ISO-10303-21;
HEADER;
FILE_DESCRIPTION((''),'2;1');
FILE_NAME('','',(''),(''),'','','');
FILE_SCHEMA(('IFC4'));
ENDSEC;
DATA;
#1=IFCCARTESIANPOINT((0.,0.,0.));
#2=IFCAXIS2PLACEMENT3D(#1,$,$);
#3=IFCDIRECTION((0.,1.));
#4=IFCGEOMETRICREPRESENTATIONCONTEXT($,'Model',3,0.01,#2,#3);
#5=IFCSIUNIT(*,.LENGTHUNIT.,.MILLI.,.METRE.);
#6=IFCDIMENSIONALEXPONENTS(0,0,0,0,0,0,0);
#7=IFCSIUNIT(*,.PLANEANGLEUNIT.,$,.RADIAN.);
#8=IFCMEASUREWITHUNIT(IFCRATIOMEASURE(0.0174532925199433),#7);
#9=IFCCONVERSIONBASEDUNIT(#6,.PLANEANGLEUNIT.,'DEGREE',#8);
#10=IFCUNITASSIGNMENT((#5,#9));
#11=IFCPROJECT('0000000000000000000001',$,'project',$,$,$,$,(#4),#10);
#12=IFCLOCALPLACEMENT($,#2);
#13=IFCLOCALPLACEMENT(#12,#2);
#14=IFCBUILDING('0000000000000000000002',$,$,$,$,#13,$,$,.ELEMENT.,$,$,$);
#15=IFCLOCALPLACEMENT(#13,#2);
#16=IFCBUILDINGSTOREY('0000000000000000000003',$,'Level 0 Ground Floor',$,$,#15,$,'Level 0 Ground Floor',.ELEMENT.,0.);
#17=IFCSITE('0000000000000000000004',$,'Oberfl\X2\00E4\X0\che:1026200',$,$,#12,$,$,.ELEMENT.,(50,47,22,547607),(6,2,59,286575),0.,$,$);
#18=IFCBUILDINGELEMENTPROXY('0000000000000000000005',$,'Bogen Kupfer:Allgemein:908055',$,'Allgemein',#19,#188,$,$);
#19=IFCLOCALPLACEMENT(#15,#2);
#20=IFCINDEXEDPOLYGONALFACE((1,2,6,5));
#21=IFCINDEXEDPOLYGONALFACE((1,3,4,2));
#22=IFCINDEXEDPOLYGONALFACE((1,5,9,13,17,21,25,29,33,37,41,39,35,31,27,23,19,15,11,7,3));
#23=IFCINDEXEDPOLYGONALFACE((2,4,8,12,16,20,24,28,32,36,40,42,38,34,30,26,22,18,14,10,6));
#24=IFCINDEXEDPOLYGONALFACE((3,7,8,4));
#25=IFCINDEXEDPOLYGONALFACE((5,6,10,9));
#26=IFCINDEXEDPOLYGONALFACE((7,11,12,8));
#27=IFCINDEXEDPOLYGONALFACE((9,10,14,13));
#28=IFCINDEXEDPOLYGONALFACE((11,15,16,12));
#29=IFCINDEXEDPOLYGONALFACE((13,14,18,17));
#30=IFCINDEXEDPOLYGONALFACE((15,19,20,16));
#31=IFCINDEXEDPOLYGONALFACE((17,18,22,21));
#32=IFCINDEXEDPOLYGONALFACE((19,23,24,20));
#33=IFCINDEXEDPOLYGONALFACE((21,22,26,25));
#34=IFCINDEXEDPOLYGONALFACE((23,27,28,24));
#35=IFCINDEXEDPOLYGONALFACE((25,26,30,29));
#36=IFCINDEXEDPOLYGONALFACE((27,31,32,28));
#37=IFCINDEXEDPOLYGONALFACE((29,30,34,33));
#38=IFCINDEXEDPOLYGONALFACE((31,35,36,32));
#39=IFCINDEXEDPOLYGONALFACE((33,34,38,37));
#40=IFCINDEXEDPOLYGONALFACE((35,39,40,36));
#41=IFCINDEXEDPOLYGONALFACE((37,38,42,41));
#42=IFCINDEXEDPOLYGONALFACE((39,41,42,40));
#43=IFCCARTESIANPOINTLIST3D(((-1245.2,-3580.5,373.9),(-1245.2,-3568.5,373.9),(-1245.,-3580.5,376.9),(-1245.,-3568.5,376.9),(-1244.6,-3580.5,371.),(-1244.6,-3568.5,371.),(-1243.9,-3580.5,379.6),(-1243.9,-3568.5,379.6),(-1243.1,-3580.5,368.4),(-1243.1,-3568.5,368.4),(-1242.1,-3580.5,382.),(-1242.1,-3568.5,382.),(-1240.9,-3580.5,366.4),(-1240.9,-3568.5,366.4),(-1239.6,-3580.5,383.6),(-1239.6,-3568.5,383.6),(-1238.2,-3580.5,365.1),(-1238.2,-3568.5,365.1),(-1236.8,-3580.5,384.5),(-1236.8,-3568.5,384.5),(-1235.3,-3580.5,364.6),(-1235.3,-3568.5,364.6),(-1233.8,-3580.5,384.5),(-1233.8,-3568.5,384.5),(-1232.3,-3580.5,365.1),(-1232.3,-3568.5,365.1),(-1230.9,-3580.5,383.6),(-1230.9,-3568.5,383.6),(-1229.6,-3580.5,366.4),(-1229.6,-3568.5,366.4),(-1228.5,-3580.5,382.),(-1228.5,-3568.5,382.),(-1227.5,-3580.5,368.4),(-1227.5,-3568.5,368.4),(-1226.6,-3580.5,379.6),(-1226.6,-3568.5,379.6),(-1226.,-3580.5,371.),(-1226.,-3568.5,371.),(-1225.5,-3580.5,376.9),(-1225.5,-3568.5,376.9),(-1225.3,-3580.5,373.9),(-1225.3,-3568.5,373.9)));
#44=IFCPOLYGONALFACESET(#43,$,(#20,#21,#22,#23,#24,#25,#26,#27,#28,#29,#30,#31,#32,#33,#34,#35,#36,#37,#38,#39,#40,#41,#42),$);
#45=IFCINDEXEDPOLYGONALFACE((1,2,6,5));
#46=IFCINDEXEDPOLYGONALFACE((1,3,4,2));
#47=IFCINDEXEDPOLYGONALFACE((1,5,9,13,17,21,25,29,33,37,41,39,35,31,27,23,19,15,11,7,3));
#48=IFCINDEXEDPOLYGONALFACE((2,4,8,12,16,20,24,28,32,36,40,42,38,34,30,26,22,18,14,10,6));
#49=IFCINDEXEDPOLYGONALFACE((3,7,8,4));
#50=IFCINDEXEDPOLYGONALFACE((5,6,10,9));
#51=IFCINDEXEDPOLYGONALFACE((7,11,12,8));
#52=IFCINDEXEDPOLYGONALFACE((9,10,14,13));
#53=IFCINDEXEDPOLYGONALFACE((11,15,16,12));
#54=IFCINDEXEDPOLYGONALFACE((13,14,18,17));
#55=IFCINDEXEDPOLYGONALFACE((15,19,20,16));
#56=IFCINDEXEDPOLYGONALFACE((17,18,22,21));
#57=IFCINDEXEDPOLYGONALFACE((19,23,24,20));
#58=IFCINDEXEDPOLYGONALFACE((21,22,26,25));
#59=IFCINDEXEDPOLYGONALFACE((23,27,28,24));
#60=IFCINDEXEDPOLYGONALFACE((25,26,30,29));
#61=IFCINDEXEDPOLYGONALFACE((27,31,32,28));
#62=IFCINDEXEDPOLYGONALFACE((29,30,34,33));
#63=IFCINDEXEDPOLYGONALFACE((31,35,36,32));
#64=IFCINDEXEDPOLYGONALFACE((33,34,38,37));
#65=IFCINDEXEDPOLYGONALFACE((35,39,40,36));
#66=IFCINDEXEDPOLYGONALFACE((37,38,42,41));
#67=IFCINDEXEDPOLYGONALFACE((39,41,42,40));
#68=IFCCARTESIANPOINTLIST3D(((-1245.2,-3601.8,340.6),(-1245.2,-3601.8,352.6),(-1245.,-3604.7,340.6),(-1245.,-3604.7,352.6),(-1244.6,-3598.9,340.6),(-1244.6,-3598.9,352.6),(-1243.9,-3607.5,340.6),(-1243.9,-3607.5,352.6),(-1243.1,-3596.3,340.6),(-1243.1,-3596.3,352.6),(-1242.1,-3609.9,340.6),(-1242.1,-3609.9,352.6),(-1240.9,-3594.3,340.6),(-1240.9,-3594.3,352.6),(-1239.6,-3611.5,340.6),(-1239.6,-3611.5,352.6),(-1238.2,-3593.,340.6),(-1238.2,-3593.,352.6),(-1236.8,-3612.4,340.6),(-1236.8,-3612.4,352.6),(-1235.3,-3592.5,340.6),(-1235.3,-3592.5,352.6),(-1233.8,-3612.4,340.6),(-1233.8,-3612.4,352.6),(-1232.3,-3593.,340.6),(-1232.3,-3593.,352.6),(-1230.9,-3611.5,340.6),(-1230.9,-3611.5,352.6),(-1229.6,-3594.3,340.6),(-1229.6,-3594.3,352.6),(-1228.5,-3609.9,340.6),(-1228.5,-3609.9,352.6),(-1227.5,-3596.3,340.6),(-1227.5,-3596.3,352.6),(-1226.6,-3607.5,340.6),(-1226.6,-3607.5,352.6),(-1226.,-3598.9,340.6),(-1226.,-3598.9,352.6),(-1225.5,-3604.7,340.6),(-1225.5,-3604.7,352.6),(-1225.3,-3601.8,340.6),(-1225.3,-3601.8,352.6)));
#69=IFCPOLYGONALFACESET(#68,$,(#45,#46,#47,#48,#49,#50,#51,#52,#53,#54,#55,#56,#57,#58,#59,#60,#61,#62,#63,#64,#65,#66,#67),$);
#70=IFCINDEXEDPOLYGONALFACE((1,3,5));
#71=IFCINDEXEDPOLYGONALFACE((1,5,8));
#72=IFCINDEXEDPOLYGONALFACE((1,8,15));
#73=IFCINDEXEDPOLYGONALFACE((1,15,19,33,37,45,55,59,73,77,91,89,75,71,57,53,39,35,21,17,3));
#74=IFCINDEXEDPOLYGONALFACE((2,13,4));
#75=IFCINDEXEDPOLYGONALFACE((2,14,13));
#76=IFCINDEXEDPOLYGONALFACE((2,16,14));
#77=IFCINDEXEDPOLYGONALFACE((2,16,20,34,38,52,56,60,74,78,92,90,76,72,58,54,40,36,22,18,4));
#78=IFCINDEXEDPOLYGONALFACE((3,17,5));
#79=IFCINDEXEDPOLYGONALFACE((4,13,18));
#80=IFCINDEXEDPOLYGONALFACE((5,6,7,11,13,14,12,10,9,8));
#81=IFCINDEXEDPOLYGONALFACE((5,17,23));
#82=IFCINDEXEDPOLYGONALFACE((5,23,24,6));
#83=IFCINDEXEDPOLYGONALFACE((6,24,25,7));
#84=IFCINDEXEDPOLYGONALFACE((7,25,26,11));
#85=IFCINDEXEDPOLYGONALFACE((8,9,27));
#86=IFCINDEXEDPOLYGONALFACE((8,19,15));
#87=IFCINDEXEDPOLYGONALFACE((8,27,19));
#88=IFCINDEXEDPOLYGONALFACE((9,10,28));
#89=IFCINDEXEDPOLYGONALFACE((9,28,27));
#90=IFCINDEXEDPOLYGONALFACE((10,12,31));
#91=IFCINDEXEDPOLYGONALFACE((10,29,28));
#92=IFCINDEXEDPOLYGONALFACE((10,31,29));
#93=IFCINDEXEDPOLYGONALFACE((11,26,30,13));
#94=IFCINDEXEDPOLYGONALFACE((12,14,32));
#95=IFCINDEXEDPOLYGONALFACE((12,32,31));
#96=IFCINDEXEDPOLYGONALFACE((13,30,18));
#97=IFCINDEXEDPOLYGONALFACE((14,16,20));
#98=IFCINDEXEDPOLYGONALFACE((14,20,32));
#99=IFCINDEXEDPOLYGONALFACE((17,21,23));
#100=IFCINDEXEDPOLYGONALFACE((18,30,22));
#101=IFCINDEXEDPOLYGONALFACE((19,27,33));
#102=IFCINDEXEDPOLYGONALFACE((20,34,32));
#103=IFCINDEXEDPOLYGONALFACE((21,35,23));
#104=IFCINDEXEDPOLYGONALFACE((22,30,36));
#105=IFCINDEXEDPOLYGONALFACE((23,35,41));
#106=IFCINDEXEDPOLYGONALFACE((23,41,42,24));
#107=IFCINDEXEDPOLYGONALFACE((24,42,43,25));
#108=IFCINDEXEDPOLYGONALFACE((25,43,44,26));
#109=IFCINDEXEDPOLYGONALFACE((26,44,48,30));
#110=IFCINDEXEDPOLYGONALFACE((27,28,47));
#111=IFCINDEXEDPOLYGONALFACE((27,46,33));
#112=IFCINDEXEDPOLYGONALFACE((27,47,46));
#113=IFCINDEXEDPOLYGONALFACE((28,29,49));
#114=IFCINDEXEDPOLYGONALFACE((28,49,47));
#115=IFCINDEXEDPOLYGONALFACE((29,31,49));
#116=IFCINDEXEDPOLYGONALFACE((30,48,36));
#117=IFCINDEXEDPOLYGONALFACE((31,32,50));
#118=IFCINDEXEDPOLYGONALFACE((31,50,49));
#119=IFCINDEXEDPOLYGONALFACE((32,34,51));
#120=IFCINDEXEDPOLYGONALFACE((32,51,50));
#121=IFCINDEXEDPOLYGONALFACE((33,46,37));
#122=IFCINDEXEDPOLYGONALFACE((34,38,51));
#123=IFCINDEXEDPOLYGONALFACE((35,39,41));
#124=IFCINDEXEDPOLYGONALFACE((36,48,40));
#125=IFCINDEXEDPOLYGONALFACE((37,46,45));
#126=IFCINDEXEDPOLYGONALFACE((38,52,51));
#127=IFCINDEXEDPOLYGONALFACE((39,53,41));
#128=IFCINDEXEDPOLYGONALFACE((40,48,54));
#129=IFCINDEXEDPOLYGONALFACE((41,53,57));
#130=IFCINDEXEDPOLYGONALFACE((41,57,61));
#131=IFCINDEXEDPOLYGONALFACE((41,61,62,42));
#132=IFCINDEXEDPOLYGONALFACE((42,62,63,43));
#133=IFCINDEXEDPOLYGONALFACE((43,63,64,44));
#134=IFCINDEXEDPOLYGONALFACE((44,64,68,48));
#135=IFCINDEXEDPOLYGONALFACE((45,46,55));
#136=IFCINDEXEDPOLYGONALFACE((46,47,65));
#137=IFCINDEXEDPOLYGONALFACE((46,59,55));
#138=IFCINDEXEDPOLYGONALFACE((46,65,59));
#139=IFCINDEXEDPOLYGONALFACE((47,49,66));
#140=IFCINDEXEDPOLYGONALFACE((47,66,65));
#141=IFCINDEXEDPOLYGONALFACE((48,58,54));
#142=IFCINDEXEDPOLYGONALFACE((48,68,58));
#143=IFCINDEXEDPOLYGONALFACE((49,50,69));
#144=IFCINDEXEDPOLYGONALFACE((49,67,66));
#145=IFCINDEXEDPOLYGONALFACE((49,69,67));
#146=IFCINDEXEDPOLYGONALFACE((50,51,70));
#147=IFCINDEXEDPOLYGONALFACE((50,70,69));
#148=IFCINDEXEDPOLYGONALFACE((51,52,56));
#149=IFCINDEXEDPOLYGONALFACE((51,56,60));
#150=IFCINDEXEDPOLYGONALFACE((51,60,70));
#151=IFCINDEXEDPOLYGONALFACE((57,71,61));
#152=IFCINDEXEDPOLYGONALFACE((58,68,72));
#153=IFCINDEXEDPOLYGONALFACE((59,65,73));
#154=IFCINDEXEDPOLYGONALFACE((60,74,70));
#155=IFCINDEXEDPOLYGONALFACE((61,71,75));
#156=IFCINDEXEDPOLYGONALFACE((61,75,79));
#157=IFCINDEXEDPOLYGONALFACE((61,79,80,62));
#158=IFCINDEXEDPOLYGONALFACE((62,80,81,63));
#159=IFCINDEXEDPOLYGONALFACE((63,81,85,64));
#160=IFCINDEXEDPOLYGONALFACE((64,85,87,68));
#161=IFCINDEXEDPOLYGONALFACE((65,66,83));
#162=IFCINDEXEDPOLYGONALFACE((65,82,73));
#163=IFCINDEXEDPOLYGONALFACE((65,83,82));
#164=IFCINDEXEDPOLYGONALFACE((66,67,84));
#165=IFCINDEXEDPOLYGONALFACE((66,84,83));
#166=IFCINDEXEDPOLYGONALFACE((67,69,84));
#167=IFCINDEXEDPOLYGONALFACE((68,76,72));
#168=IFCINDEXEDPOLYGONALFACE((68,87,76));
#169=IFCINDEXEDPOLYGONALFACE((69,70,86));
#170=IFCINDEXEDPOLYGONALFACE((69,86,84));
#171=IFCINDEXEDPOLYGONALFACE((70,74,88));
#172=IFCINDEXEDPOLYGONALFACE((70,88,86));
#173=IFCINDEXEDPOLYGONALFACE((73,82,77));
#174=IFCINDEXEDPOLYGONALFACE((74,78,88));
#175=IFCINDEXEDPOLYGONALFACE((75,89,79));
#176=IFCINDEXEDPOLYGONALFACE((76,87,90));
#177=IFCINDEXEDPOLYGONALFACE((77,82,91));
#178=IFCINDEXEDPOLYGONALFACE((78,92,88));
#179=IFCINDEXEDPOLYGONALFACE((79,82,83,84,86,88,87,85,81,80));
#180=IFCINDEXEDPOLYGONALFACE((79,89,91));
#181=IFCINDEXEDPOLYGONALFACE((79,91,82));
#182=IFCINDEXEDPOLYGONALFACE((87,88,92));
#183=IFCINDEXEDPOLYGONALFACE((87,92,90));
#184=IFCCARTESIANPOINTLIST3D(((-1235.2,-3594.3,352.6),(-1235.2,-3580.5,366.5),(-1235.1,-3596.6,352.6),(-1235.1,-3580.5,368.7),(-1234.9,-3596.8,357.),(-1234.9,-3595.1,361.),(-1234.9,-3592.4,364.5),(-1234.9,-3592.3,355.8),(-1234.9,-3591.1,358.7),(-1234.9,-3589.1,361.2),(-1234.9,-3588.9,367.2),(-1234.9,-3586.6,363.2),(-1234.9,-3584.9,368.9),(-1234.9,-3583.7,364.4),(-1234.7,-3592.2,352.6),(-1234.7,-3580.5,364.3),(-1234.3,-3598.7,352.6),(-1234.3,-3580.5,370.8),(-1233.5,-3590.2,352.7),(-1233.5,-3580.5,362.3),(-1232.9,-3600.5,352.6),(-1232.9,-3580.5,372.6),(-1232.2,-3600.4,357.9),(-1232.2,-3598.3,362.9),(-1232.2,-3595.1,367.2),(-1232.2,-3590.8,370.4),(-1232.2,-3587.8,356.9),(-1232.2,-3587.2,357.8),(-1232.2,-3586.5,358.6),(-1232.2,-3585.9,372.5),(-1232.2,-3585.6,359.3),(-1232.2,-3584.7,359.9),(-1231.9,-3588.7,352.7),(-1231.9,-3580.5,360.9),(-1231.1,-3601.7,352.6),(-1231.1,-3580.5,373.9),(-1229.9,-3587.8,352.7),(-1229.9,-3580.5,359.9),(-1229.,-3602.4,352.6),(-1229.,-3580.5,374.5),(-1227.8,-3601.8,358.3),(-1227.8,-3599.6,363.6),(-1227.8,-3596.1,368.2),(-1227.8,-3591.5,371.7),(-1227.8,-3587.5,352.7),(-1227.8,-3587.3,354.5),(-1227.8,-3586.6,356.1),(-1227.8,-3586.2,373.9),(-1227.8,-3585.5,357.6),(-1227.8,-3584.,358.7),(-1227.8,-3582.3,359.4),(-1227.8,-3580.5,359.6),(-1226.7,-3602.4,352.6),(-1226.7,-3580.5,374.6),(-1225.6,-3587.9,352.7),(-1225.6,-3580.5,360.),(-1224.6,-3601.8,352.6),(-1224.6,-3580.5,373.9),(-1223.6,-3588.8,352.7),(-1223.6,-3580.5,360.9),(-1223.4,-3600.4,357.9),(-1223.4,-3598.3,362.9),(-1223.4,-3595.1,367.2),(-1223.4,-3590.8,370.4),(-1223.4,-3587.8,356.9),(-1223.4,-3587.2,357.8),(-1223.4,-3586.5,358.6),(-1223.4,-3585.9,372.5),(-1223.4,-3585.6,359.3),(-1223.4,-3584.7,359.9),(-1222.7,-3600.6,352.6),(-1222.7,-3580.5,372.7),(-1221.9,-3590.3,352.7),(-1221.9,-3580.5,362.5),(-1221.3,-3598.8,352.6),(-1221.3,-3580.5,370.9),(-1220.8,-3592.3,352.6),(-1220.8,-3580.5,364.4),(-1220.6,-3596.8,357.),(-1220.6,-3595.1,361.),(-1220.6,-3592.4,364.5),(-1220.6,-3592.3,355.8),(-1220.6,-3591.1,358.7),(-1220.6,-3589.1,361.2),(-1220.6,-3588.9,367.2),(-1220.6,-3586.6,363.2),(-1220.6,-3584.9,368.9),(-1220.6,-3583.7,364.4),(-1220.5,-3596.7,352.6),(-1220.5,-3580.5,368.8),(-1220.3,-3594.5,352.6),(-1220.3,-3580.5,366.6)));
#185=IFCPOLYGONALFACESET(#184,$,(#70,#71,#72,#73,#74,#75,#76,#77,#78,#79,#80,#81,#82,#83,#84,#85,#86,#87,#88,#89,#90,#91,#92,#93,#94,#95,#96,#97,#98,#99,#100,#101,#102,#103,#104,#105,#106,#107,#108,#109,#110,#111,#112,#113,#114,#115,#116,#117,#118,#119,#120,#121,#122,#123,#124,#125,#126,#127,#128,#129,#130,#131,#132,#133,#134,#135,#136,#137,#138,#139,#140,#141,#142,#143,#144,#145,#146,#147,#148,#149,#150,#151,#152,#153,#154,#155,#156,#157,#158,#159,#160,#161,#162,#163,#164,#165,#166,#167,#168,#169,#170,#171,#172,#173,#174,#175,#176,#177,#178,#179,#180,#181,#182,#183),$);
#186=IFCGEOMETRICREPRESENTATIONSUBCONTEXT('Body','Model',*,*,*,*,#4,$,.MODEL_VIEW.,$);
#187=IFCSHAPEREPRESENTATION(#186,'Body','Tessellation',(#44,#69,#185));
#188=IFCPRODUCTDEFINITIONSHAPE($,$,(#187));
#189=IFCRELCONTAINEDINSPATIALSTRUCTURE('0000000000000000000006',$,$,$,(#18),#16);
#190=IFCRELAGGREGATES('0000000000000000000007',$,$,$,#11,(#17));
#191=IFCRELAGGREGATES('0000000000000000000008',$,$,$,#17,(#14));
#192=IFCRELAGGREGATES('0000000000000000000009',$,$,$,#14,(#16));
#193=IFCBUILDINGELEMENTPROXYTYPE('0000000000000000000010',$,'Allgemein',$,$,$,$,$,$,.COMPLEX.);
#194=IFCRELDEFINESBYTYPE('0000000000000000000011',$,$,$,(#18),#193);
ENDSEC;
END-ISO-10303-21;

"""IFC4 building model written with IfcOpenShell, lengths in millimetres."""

from ifc_helpers import new_model, entity, si_unit, converted_unit, direction, frame, frame_2d, origin, place, context, subcontext, project, spatial, circle, extrude, source, transform, mapped, type_object, type_shapes, element, save


model = new_model("IFC4")

# Units and contexts
model_context = context("Model", 3, precision=0.01, world=origin(), true_north=direction((0.0, 1.0)))
body_context = subcontext(model_context, "Body", "Model", "MODEL_VIEW")
ifc_project = project(units=[si_unit("LENGTHUNIT", "METRE", prefix="MILLI"), converted_unit("PLANEANGLEUNIT", "DEGREE", entity("IfcRatioMeasure", 0.0174532925199433), si_unit("PLANEANGLEUNIT", "RADIAN"), dimensions=[0, 0, 0, 0, 0, 0, 0])], contexts=[model_context])

# Site, building, storey
site_placement = place(None, origin())
site = spatial("IfcSite", under=ifc_project, at=site_placement, Name="Oberfläche:1026200", CompositionType="ELEMENT", RefLatitude=(50, 47, 22, 547607), RefLongitude=(6, 2, 59, 286575), RefElevation=0.0)
building_placement = place(site_placement, origin())
building = spatial("IfcBuilding", under=site, at=building_placement, CompositionType="ELEMENT")
storey_placement = place(building_placement, origin())
storey = spatial("IfcBuildingStorey", under=building, at=storey_placement, Name="Level 0 Ground Floor", LongName="Level 0 Ground Floor", CompositionType="ELEMENT", Elevation=0.0)

# Building element proxy
building_element_proxy_type = type_object("IfcBuildingElementProxyType", Name="Allgemein", PredefinedType="COMPLEX")
ifc_direction = entity("IfcDirection", [0.0, 0.0, -1.0])
trimmed_curve = entity("IfcTrimmedCurve", entity("IfcCircle", entity("IfcAxis2Placement2D", entity("IfcCartesianPoint", [-14.5, 0.0]), entity("IfcDirection", [0.0, 1.0])), 14.5), [entity("IfcParameterValue", 270.0)], [entity("IfcParameterValue", 0.0)], True, "PARAMETER")
shared_shape_1 = source(origin(), body_context, "Body", "SolidModel", [
    extrude(circle(Radius=10.0, at=frame_2d((0.0, 0.0), x_axis=(1.0, 0.0))), frame((0.0, 22.0, 0.0), z_axis=(0.0, 1.0, 0.0), x_axis=(-1.0, 0.0, 0.0)), (0.0, 0.0, 1.0), 12.0),
    extrude(circle(Radius=10.0, at=frame_2d((0.0, 0.0), x_axis=(1.0, 0.0))), frame((-34.0, 0.0, 0.0), z_axis=(1.0, 0.0, 0.0), x_axis=(0.0, 1.0, 0.0)), (0.0, 0.0, 1.0), 12.0),
    entity("IfcSurfaceCurveSweptAreaSolid", entity("IfcCircleProfileDef", "AREA", None, entity("IfcAxis2Placement2D", entity("IfcCartesianPoint", [0.0, 7.5]), entity("IfcDirection", [1.0, 0.0])), 7.5), entity("IfcAxis2Placement3D", entity("IfcCartesianPoint", [-7.5, 22.0, 0.0]), ifc_direction, entity("IfcDirection", [1.0, 0.0, 0.0])), trimmed_curve, 0.0, 90.0, entity("IfcSurfaceOfLinearExtrusion", entity("IfcArbitraryOpenProfileDef", "CURVE", None, trimmed_curve), entity("IfcAxis2Placement3D", entity("IfcCartesianPoint", [0.0, 0.0, -304.8])), ifc_direction, 1.0)),
])
type_shapes(building_element_proxy_type, [shared_shape_1])
for number, where, z_axis, x_axis, name in (
    (1, (-1235.3, -3602.5, 374.6), (-1.0, 0.0, 0.0), (0.0, 0.0, 1.0), "Bogen Kupfer:Allgemein:908055"),
):
    element("IfcBuildingElementProxy", number, at=place(storey_placement, frame(where, z_axis=z_axis, x_axis=x_axis)), inside=storey, type_object=building_element_proxy_type, Name=name, ObjectType="Allgemein", context=body_context, shape_type="MappedRepresentation", body=[
        mapped(shared_shape_1, transform((0.0, 0.0, 0.0), scale=1.0)),
    ])

save(model, "model.ifc")
